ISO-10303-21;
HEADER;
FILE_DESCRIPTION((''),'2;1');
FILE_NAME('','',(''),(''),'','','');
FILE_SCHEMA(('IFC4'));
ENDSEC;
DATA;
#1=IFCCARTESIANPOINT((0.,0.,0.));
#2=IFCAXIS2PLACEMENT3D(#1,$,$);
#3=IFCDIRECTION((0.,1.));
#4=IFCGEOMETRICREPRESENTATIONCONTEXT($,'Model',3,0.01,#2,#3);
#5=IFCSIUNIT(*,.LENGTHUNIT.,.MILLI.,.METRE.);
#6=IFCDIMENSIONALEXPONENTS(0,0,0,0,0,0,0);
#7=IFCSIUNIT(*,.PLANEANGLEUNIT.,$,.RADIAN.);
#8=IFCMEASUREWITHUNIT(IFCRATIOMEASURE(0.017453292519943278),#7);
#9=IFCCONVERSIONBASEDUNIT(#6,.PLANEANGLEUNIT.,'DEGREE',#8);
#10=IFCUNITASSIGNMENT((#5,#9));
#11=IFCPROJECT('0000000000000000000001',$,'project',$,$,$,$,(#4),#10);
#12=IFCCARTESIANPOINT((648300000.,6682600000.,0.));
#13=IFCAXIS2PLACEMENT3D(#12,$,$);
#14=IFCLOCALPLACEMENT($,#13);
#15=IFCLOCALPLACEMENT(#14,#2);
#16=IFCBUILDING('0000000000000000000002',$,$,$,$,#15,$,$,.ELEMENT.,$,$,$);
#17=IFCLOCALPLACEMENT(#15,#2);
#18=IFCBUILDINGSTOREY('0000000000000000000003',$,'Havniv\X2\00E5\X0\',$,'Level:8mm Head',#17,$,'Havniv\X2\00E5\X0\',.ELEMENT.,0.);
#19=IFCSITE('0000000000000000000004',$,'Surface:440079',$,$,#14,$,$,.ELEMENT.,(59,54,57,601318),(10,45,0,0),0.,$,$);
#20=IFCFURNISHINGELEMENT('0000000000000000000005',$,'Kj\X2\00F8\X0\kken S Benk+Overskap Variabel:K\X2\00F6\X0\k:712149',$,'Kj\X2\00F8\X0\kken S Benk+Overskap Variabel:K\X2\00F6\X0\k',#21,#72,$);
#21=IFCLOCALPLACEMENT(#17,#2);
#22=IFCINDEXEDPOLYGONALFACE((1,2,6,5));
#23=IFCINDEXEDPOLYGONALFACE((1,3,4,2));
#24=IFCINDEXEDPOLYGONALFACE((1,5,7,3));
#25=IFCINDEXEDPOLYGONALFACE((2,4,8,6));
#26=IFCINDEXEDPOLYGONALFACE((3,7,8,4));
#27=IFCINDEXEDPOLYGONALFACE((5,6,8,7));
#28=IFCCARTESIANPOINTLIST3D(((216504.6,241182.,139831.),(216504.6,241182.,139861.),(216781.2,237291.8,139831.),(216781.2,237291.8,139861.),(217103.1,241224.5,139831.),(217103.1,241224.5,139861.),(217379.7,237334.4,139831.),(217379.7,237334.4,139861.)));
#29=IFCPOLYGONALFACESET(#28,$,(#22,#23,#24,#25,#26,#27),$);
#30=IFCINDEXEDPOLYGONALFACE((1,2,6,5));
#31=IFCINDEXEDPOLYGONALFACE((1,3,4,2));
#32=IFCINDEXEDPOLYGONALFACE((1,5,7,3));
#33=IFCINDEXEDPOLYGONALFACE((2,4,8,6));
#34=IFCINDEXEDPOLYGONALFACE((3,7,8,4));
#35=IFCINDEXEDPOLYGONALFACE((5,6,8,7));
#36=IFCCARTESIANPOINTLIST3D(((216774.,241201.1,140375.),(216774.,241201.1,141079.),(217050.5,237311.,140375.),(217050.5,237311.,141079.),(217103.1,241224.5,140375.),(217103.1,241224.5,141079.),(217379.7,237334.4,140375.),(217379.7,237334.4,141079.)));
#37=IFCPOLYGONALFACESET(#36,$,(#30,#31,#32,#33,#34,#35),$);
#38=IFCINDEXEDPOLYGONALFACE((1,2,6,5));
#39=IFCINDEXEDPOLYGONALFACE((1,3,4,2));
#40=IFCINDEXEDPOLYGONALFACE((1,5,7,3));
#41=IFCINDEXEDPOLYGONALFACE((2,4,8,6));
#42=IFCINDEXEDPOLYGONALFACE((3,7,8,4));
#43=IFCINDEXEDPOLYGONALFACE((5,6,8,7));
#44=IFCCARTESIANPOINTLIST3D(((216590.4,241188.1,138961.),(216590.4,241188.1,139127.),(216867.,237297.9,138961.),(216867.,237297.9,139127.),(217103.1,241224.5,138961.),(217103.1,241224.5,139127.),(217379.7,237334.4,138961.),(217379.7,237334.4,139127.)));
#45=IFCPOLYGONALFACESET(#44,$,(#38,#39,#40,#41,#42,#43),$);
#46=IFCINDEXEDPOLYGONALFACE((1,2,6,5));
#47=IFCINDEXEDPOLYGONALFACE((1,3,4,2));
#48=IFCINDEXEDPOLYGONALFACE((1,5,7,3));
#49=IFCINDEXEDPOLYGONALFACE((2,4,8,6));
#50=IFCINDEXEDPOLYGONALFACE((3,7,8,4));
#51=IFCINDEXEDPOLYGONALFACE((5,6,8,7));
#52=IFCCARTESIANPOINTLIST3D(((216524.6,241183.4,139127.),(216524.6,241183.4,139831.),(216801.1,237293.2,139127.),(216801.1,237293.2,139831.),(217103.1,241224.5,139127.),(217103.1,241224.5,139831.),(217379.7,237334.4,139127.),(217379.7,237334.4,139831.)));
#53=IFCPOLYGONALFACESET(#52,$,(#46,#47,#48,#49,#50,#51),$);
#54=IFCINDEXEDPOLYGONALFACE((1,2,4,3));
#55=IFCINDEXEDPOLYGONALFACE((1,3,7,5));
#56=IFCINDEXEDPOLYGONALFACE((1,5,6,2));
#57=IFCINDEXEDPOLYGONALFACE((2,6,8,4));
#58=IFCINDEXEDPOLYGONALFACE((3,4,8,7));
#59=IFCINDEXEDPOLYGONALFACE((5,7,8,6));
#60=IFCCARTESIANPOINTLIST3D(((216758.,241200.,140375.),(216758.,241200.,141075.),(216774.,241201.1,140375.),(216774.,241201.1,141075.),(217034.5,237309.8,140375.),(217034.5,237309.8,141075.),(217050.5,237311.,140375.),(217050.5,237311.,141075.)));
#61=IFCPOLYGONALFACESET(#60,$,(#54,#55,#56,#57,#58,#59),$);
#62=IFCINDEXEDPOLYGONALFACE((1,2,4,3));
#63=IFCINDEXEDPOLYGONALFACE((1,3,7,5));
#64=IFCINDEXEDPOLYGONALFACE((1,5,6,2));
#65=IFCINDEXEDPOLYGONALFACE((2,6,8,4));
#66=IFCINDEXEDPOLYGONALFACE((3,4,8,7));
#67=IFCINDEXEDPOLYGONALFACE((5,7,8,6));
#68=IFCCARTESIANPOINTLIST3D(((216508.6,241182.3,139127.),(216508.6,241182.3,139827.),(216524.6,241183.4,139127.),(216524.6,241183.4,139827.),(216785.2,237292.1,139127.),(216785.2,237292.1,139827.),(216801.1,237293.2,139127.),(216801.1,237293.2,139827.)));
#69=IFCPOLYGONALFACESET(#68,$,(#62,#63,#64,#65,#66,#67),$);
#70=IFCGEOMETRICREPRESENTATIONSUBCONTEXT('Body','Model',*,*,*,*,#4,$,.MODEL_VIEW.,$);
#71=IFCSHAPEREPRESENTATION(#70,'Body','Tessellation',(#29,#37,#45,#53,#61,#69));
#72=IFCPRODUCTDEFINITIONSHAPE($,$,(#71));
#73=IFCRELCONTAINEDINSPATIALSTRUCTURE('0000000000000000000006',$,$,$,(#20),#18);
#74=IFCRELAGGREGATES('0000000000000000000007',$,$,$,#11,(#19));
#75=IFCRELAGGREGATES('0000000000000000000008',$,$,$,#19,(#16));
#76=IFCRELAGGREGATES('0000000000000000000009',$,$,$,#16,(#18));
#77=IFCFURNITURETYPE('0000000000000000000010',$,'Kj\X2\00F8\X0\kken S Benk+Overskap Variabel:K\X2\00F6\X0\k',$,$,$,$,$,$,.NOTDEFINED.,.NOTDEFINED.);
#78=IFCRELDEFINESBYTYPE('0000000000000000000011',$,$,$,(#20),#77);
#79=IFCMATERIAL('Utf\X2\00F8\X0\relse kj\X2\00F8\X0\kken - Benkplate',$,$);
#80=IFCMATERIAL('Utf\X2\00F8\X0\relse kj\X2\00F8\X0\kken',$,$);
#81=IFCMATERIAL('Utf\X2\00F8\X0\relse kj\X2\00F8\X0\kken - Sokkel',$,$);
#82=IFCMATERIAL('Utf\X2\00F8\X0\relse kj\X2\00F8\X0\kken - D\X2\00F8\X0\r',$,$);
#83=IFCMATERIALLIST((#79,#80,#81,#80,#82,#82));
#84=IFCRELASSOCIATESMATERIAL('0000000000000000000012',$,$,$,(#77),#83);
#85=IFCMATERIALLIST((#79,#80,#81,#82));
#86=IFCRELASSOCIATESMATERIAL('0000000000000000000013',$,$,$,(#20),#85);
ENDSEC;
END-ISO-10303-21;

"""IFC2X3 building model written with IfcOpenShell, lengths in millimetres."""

from ifc_helpers import new_model, entity, si_unit, converted_unit, direction, frame, frame_2d, origin, origin_2d_with_axis, place, context, subcontext, project, spatial, rectangle, extrude, source, transform, mapped, material, material_list, type_object, type_shapes, element, save


model = new_model("IFC2X3")

# Units and contexts
model_context = context("Model", 3, precision=0.01, world=origin(), true_north=direction((0.0, 1.0)))
body_context = subcontext(model_context, "Body", "Model", "MODEL_VIEW")
ifc_project = project(units=[si_unit("LENGTHUNIT", "METRE", prefix="MILLI"), converted_unit("PLANEANGLEUNIT", "DEGREE", entity("IfcRatioMeasure", 0.017453292519943278), si_unit("PLANEANGLEUNIT", "RADIAN"), dimensions=[0, 0, 0, 0, 0, 0, 0])], contexts=[model_context])

# Site, building, storey
site_placement = place(None, frame((648300000.0, 6682600000.0, 0.0)))
site = spatial("IfcSite", under=ifc_project, at=site_placement, Name="Surface:440079", CompositionType="ELEMENT", RefLatitude=(59, 54, 57, 601318), RefLongitude=(10, 45, 0, 0), RefElevation=0.0)
building_placement = place(site_placement, origin())
building = spatial("IfcBuilding", under=site, at=building_placement, CompositionType="ELEMENT")
storey_placement = place(building_placement, origin())
storey = spatial("IfcBuildingStorey", under=building, at=storey_placement, Name="Havnivå", ObjectType="Level:8mm Head", LongName="Havnivå", CompositionType="ELEMENT", Elevation=0.0)

# Furnishing element
ifc_material_1 = material(Name="Utførelse kjøkken - Benkplate")
ifc_material_2 = material(Name="Utførelse kjøkken")
ifc_material_3 = material(Name="Utførelse kjøkken - Sokkel")
ifc_material_4 = material(Name="Utførelse kjøkken - Dør")
ifc_material_list_1 = material_list([ifc_material_1, ifc_material_2, ifc_material_3, ifc_material_4])
ifc_material_list_2 = material_list([ifc_material_1, ifc_material_2, ifc_material_3, ifc_material_2, ifc_material_4, ifc_material_4])
furniture_type = type_object("IfcFurnitureType", Name="Kjøkken S Benk+Overskap Variabel:Kök", material=ifc_material_list_2)
shared_shape_1 = source(origin(), body_context, "Body", "SweptSolid", [
    extrude(rectangle(XDim=600.0, YDim=3900.0, at=origin_2d_with_axis()), frame((1950.0, 300.0, 870.0), z_axis=(0.0, 0.0, 1.0), x_axis=(0.0, 1.0, 0.0)), (0.0, 0.0, 1.0), 30.0),
    extrude(rectangle(XDim=330.0, YDim=3900.0, at=origin_2d_with_axis()), frame((1950.0, 165.0, 1414.0), z_axis=(0.0, 0.0, 1.0), x_axis=(0.0, 1.0, 0.0)), (0.0, 0.0, 1.0), 704.0),
    extrude(rectangle(XDim=514.0, YDim=3900.0, at=origin_2d_with_axis()), frame((1950.0, 257.0, 0.0), z_axis=(0.0, 0.0, 1.0), x_axis=(0.0, 1.0, 0.0)), (0.0, 0.0, 1.0), 166.0),
    extrude(rectangle(XDim=580.0, YDim=3900.0, at=origin_2d_with_axis()), frame((1950.0, 290.0, 166.0), z_axis=(0.0, 0.0, 1.0), x_axis=(0.0, 1.0, 0.0)), (0.0, 0.0, 1.0), 704.0),
    extrude(rectangle(XDim=16.0, YDim=3900.0, at=origin_2d_with_axis()), frame((1950.0, 338.0, 1414.0), z_axis=(0.0, 0.0, 1.0), x_axis=(0.0, -1.0, 0.0)), (0.0, 0.0, 1.0), 700.0),
    extrude(rectangle(XDim=16.0, YDim=3900.0, at=frame_2d((0.0, 0.0), x_axis=(1.0, 0.0))), frame((1950.0, 588.0, 166.0), z_axis=(0.0, 0.0, 1.0), x_axis=(0.0, -1.0, 0.0)), (0.0, 0.0, 1.0), 700.0),
])
type_shapes(furniture_type, [shared_shape_1])
furnishing_placement = place(storey_placement, frame((217379.7, 237334.4, 138961.0), z_axis=(0.0, 0.0, 1.0), x_axis=(-0.070908, 0.997483, 0.0)))
element("IfcFurnishingElement", 1, at=furnishing_placement, inside=storey, type_object=furniture_type, material=ifc_material_list_1, Name="Kjøkken S Benk+Overskap Variabel:Kök:712149", ObjectType="Kjøkken S Benk+Overskap Variabel:Kök", context=body_context, shape_type="MappedRepresentation", body=[
    mapped(shared_shape_1, transform((0.0, 0.0, 0.0), scale=1.0)),
])

save(model, "model.ifc")
